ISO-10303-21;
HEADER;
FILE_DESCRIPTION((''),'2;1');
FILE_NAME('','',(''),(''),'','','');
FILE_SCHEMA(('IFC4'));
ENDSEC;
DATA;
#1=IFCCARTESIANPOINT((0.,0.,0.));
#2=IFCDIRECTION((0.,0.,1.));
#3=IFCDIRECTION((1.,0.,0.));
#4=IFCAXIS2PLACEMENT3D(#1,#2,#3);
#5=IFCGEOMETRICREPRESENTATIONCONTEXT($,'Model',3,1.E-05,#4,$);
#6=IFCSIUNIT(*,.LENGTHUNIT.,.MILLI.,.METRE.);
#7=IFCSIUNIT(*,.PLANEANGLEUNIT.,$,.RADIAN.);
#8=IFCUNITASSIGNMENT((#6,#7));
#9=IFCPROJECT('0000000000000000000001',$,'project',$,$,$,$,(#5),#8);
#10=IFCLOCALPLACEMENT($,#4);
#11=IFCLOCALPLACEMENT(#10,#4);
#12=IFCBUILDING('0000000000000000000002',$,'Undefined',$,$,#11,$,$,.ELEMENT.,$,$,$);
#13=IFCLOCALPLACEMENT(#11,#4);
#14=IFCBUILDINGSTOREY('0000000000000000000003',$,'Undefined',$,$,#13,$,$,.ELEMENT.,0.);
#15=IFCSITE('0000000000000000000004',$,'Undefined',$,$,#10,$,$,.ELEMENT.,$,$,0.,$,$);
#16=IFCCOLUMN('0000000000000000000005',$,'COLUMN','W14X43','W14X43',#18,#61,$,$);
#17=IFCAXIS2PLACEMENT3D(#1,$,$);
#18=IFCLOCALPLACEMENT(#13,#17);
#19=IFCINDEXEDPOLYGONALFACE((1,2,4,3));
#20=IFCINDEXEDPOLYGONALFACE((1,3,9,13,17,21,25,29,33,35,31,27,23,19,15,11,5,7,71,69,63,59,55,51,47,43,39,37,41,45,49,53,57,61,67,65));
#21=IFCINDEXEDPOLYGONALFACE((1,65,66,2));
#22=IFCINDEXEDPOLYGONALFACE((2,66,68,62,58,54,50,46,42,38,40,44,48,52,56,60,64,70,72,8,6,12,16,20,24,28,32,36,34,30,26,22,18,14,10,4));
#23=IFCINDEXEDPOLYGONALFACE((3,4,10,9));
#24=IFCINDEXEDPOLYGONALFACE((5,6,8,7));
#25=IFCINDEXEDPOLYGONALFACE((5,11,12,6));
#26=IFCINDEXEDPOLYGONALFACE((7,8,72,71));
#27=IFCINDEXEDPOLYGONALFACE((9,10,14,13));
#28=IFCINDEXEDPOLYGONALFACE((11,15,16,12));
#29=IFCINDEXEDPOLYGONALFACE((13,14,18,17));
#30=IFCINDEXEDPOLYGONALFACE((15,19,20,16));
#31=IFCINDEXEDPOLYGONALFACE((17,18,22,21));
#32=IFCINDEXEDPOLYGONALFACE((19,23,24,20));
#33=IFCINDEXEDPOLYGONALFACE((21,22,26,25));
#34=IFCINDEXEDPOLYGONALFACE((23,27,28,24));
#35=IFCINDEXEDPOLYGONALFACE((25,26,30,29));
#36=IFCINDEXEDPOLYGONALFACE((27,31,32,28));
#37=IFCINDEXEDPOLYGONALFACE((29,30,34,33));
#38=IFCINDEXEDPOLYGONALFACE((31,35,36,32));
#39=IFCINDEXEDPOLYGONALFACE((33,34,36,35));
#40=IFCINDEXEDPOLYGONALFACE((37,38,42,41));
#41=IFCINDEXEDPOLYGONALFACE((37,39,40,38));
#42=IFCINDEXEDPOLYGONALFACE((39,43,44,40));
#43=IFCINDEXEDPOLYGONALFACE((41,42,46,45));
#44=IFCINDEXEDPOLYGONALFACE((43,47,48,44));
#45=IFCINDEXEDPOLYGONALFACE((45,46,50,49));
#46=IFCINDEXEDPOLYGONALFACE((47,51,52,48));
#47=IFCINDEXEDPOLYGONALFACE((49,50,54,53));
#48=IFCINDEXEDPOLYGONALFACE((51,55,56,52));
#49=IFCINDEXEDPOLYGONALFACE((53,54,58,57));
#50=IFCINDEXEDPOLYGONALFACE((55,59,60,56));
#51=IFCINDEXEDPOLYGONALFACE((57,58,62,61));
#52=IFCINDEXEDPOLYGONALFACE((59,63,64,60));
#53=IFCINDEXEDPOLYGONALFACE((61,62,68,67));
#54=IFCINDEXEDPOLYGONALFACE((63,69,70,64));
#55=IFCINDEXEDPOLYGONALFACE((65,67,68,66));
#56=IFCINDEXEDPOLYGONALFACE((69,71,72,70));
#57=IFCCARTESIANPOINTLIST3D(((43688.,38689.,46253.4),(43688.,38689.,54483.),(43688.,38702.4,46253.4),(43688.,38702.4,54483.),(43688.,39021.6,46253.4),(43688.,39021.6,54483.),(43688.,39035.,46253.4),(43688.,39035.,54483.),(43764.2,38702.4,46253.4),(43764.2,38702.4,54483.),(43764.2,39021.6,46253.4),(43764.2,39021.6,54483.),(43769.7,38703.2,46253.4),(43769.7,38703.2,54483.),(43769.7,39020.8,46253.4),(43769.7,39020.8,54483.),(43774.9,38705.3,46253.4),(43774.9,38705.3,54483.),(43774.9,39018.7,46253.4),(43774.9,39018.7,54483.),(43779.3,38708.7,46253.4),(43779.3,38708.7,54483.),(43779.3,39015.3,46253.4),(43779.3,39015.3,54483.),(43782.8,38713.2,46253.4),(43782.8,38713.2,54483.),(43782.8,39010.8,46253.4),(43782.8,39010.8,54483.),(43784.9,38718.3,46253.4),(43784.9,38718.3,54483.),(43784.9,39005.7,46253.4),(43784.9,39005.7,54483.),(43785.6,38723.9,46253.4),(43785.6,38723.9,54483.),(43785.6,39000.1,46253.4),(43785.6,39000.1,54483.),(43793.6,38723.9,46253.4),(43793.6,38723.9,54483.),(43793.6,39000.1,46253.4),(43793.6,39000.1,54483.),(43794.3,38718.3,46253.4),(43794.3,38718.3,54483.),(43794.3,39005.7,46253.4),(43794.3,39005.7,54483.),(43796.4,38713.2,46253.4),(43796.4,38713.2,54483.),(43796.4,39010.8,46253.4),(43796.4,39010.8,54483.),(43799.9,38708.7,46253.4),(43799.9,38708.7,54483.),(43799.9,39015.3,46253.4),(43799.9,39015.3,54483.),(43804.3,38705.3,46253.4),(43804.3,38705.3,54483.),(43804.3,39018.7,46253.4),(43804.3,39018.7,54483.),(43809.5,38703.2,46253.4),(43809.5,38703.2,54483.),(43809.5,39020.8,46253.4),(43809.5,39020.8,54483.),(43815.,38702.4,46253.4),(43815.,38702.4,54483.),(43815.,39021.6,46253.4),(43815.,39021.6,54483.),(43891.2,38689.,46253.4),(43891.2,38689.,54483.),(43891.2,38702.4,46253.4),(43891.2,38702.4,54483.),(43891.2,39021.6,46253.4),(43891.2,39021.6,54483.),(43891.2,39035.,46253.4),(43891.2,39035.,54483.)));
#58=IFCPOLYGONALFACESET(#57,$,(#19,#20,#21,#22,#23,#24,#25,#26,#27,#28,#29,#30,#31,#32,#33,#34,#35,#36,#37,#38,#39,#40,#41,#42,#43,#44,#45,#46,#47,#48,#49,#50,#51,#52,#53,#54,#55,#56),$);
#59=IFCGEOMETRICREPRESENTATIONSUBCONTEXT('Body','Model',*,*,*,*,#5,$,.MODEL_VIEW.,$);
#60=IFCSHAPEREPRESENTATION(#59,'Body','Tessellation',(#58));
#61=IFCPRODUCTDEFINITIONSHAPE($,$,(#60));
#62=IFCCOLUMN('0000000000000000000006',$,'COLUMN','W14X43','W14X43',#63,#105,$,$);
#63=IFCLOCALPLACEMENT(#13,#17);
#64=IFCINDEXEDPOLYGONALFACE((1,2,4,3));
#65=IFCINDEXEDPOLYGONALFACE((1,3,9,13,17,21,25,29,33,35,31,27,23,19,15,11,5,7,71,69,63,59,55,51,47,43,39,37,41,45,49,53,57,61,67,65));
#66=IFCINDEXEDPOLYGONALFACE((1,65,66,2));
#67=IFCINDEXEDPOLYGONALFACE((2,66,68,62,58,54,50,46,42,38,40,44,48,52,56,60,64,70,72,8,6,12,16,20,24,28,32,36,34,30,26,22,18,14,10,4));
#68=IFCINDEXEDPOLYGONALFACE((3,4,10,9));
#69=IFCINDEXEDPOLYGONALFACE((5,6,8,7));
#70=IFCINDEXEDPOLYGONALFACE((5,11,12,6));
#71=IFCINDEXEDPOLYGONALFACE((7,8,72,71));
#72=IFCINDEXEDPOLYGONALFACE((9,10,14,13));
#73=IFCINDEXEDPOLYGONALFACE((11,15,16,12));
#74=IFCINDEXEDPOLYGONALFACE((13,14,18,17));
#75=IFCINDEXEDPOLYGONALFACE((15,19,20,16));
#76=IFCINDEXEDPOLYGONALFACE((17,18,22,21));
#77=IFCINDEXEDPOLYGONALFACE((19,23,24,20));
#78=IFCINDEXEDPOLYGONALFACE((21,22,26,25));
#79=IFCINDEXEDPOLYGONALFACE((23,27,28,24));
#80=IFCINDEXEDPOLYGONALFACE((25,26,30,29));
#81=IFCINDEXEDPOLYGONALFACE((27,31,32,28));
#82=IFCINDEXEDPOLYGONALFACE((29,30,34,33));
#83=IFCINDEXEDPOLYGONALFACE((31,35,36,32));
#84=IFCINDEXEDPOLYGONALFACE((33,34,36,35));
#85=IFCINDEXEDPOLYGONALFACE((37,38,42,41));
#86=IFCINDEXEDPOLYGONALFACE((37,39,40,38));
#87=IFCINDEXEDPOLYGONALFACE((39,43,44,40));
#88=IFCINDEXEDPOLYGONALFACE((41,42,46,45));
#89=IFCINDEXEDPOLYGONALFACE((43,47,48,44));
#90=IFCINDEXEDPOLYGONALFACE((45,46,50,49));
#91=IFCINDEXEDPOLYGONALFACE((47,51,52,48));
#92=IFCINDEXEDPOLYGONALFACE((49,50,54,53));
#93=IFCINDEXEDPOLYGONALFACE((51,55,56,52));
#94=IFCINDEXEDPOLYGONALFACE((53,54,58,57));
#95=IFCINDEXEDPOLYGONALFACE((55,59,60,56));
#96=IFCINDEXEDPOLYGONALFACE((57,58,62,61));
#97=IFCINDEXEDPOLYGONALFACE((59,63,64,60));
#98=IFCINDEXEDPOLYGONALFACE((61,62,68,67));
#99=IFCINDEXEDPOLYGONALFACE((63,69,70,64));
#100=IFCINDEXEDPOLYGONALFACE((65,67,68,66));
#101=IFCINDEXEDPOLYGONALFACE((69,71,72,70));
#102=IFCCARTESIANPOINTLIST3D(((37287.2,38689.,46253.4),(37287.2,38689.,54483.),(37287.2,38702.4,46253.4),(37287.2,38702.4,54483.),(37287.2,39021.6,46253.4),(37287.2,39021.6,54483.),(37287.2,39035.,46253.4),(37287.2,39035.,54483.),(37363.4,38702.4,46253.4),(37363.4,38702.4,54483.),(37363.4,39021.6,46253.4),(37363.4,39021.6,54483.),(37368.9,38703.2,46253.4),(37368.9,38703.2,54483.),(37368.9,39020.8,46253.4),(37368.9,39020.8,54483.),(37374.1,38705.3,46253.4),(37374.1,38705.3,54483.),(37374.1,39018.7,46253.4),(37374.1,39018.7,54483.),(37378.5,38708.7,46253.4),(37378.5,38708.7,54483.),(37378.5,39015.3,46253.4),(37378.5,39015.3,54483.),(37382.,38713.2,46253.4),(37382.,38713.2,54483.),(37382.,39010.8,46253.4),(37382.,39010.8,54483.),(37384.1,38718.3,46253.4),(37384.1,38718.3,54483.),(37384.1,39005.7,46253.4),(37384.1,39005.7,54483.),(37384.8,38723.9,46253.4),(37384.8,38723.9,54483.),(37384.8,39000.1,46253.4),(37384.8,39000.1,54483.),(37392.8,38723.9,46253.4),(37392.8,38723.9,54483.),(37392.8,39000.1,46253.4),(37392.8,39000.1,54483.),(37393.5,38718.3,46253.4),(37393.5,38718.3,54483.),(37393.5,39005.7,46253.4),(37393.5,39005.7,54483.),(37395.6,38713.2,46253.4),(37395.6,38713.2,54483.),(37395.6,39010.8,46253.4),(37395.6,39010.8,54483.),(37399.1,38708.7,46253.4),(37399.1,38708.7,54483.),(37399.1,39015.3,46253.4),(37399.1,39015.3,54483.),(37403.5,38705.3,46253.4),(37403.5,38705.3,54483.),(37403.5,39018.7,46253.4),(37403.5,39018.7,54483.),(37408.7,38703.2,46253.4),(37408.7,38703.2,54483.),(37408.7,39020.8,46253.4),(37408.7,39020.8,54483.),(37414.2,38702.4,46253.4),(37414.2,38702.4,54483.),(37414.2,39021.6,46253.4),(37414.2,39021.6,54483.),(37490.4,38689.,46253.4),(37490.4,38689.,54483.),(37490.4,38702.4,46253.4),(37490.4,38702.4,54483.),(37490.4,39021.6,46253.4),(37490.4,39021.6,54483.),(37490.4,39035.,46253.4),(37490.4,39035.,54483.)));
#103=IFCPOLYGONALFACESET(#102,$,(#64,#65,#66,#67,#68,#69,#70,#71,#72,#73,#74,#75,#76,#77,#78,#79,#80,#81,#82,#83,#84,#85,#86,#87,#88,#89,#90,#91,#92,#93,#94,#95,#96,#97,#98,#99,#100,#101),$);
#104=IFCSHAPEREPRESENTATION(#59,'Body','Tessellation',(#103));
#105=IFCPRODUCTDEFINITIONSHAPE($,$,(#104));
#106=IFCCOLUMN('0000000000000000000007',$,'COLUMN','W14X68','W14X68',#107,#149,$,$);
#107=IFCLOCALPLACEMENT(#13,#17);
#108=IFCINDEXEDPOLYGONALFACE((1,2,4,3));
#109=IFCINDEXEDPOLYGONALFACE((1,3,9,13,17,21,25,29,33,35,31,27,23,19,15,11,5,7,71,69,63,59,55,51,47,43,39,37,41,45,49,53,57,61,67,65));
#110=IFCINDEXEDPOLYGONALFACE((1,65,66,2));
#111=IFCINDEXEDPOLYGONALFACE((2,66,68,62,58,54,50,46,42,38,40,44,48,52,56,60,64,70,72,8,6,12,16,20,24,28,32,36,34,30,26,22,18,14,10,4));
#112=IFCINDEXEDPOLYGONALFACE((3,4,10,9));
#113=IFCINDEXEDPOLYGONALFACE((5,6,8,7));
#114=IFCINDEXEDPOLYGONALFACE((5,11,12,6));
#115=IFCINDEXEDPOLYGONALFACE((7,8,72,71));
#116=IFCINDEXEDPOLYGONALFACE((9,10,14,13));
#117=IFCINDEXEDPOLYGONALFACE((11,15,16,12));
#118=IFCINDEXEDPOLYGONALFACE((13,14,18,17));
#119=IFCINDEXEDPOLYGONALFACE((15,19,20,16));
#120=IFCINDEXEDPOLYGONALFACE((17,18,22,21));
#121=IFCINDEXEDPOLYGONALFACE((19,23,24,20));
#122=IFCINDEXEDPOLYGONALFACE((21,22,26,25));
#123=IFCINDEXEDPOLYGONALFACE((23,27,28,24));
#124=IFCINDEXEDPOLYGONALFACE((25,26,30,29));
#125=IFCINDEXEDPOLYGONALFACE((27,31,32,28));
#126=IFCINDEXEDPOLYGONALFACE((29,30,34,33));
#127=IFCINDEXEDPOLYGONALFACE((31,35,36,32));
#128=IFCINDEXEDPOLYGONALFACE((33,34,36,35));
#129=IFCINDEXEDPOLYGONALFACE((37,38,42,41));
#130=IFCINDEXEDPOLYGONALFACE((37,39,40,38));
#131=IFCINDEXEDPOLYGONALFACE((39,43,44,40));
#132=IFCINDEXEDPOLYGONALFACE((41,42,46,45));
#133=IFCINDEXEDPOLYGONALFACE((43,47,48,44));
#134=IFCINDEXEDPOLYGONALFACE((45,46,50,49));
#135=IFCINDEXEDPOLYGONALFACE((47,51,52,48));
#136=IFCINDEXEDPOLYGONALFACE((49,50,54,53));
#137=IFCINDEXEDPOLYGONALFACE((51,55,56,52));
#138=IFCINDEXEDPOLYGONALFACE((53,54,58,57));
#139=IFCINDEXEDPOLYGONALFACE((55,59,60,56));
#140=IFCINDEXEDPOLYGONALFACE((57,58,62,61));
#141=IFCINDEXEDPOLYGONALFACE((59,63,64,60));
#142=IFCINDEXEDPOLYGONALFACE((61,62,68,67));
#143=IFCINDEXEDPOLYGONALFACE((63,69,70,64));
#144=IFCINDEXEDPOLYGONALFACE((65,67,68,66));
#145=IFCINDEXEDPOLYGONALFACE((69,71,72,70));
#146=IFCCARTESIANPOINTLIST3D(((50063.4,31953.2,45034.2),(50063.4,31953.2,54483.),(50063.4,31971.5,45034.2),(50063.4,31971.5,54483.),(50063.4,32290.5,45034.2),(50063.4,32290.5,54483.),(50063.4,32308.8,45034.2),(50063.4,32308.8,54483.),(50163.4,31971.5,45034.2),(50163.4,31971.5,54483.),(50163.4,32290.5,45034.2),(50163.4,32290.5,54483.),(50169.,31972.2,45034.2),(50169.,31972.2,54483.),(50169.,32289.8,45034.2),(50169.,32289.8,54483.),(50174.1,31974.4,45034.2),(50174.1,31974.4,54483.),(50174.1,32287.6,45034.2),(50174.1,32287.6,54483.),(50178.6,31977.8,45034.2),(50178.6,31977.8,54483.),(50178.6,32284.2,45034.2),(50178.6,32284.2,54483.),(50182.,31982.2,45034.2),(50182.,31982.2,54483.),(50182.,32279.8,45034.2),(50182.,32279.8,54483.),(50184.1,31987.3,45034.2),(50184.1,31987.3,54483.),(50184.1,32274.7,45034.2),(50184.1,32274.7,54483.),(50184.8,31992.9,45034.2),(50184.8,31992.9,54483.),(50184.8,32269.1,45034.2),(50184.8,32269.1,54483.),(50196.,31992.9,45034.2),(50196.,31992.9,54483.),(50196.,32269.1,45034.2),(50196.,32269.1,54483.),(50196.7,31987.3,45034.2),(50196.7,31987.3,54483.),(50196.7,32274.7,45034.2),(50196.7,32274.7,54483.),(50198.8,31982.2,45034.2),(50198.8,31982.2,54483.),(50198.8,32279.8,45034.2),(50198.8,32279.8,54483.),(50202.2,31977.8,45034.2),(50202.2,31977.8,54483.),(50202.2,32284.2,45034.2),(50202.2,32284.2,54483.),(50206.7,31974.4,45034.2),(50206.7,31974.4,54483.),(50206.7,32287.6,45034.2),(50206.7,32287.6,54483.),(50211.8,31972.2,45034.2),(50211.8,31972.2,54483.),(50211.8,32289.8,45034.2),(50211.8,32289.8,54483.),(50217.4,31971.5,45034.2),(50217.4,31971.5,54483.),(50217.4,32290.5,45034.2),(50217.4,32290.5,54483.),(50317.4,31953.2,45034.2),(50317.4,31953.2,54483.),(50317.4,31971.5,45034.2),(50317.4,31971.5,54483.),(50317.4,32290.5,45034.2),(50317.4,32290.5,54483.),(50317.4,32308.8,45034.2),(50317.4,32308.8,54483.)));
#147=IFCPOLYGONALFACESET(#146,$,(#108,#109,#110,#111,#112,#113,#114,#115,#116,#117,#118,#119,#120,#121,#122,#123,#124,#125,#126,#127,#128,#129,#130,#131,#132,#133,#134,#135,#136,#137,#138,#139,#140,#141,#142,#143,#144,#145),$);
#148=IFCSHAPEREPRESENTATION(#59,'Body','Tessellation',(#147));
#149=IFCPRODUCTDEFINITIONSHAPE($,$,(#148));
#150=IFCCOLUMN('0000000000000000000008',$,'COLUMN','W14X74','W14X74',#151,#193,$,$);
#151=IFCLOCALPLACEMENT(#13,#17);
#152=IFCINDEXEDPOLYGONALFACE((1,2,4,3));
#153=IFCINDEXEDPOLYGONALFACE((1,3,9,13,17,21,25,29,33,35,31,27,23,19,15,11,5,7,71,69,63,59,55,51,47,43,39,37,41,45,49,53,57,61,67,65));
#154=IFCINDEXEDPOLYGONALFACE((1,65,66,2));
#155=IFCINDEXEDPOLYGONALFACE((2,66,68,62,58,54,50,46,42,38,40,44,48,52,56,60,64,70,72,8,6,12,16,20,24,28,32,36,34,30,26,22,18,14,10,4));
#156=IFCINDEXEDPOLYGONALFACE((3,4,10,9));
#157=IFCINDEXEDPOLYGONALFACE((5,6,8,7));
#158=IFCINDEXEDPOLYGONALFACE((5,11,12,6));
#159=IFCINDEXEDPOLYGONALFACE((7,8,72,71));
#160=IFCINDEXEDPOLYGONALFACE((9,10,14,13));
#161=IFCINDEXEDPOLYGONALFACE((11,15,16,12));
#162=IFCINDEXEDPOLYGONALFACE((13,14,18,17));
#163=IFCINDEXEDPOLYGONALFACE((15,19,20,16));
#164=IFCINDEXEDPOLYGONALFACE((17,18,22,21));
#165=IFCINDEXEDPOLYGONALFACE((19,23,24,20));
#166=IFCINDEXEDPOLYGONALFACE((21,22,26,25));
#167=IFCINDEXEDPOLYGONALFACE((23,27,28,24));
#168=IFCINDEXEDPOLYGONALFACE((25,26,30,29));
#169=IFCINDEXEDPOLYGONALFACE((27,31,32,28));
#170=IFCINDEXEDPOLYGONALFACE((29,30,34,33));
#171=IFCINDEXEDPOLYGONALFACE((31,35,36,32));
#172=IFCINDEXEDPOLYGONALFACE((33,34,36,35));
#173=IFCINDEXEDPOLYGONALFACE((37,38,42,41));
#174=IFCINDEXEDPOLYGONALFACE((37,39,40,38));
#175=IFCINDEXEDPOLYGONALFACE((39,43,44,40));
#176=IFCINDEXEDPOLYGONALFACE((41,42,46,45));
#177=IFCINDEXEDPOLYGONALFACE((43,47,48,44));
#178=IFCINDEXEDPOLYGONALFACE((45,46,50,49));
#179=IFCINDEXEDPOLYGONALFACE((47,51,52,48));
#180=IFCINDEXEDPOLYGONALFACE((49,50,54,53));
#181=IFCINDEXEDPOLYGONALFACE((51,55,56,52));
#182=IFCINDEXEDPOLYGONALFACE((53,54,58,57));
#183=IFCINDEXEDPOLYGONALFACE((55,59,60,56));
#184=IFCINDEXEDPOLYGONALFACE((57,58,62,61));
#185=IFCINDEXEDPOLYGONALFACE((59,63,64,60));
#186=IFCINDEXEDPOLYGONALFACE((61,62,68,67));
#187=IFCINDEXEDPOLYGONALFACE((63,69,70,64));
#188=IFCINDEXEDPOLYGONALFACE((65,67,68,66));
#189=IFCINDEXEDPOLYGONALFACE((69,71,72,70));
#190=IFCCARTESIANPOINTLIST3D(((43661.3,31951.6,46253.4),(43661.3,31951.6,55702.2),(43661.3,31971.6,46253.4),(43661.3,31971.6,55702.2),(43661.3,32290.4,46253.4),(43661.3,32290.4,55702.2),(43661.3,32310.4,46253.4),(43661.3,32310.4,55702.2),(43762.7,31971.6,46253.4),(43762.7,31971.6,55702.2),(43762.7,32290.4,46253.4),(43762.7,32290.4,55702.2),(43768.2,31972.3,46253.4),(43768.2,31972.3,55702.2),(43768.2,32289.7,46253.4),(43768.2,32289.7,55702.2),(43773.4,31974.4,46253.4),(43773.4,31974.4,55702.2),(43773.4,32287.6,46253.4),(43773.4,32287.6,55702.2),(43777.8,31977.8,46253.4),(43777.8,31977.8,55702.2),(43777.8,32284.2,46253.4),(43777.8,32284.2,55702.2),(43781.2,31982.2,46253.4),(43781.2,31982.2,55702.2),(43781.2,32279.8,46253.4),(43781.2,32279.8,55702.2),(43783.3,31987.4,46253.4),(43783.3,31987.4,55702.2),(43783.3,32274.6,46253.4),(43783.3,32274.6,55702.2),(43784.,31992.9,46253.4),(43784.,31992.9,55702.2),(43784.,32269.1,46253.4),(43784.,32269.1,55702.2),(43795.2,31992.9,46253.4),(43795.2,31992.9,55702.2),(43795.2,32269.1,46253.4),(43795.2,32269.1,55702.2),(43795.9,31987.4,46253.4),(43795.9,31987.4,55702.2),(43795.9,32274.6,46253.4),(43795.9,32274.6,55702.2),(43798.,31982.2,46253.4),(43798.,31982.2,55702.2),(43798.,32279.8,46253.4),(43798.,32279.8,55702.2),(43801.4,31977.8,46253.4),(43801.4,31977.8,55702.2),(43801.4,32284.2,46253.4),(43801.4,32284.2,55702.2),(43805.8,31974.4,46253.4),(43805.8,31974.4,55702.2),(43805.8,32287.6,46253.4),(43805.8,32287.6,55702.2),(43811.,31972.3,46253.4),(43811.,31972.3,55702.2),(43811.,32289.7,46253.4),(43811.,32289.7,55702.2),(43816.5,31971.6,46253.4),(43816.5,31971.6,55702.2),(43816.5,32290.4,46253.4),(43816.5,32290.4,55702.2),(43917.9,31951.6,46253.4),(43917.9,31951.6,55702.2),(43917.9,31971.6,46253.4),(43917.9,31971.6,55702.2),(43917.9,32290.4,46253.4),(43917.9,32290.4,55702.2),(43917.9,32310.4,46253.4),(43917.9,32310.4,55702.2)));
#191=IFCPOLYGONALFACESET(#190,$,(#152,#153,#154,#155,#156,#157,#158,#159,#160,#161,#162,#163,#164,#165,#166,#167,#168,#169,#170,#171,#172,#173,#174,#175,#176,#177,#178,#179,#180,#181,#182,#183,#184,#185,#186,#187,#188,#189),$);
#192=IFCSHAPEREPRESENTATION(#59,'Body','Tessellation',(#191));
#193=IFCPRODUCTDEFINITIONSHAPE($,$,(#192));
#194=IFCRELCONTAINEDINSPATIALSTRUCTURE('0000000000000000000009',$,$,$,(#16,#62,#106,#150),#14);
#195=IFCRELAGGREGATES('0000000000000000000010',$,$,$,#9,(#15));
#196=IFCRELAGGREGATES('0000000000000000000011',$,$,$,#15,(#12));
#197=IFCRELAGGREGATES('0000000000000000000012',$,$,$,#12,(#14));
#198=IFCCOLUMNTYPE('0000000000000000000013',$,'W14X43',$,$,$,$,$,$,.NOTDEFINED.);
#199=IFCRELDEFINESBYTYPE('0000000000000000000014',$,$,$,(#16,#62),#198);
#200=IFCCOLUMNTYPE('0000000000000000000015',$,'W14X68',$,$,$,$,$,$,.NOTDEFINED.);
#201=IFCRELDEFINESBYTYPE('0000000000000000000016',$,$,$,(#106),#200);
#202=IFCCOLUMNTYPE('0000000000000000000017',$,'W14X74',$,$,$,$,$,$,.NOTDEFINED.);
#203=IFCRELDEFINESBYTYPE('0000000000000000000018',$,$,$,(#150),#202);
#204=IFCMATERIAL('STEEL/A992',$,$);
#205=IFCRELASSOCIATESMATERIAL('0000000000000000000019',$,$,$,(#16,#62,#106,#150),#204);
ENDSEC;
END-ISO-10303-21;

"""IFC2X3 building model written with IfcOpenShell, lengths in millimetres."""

from ifc_helpers import new_model, si_unit, frame, origin_with_axes, origin_2d_with_axis, place, context, subcontext, project, spatial, i_section, extrude, material, type_object, element, save


model = new_model("IFC2X3")

# Units and contexts
model_context = context("Model", 3, precision=1e-05, world=origin_with_axes())
body_context = subcontext(model_context, "Body", "Model", "MODEL_VIEW")
ifc_project = project(units=[si_unit("LENGTHUNIT", "METRE", prefix="MILLI"), si_unit("PLANEANGLEUNIT", "RADIAN")], contexts=[model_context])

# Site, building, storey
site_placement = place(None, origin_with_axes())
site = spatial("IfcSite", under=ifc_project, at=site_placement, Name="Undefined", CompositionType="ELEMENT", RefElevation=0.0)
building_placement = place(site_placement, origin_with_axes())
building = spatial("IfcBuilding", under=site, at=building_placement, Name="Undefined", CompositionType="ELEMENT")
storey_placement = place(building_placement, origin_with_axes())
storey = spatial("IfcBuildingStorey", under=building, at=storey_placement, Name="Undefined", CompositionType="ELEMENT", Elevation=0.0)

# Columns
ifc_material = material(Name="STEEL/A992")
column_type_1 = type_object("IfcColumnType", Name="W14X43", PredefinedType="NOTDEFINED")
for number, where, z_axis, x_axis, name in (
    (1, (43789.6, 38862.0, 46253.4), (0.0, 0.0, 1.0), (1.0, 0.0, 0.0), "COLUMN"),
    (2, (37388.8, 38862.0, 46253.4), (0.0, 0.0, 1.0), (1.0, 0.0, 0.0), "COLUMN"),
):
    element("IfcColumn", number, at=place(storey_placement, frame(where, z_axis=z_axis, x_axis=x_axis)), inside=storey, type_object=column_type_1, material=ifc_material, Name=name, Description="W14X43", ObjectType="W14X43", context=body_context, shape_type="SweptSolid", body=[
        extrude(i_section(OverallWidth=203.2, OverallDepth=346.1, WebThickness=7.9, FlangeThickness=13.5, FilletRadius=21.5, at=origin_2d_with_axis()), frame((0.0, 0.0, 8229.6), z_axis=(0.0, 0.0, -1.0), x_axis=(-1.0, 0.0, 0.0)), (0.0, 0.0, 1.0), 8229.6),
    ])
column_type_2 = type_object("IfcColumnType", Name="W14X68", PredefinedType="NOTDEFINED")
column_1_placement = place(storey_placement, frame((50190.4, 32131.0, 45034.2), z_axis=(0.0, 0.0, 1.0), x_axis=(1.0, 0.0, 0.0)))
element("IfcColumn", 3, at=column_1_placement, inside=storey, type_object=column_type_2, material=ifc_material, Name="COLUMN", Description="W14X68", ObjectType="W14X68", context=body_context, shape_type="SweptSolid", body=[
    extrude(i_section(OverallWidth=254.0, OverallDepth=355.6, WebThickness=11.1, FlangeThickness=18.3, FilletRadius=21.4, at=origin_2d_with_axis()), frame((0.0, 0.0, 9448.8), z_axis=(0.0, 0.0, -1.0), x_axis=(-1.0, 0.0, 0.0)), (0.0, 0.0, 1.0), 9448.8),
])
column_type_3 = type_object("IfcColumnType", Name="W14X74", PredefinedType="NOTDEFINED")
column_2_placement = place(storey_placement, frame((43789.6, 32131.0, 46253.4), z_axis=(0.0, 0.0, 1.0), x_axis=(1.0, 0.0, 0.0)))
element("IfcColumn", 4, at=column_2_placement, inside=storey, type_object=column_type_3, material=ifc_material, Name="COLUMN", Description="W14X74", ObjectType="W14X74", context=body_context, shape_type="SweptSolid", body=[
    extrude(i_section(OverallWidth=256.5, OverallDepth=358.8, WebThickness=11.1, FlangeThickness=19.9, FilletRadius=21.3, at=origin_2d_with_axis()), frame((0.0, 0.0, 9448.8), z_axis=(0.0, 0.0, -1.0), x_axis=(-1.0, 0.0, 0.0)), (0.0, 0.0, 1.0), 9448.8),
])

save(model, "model.ifc")
